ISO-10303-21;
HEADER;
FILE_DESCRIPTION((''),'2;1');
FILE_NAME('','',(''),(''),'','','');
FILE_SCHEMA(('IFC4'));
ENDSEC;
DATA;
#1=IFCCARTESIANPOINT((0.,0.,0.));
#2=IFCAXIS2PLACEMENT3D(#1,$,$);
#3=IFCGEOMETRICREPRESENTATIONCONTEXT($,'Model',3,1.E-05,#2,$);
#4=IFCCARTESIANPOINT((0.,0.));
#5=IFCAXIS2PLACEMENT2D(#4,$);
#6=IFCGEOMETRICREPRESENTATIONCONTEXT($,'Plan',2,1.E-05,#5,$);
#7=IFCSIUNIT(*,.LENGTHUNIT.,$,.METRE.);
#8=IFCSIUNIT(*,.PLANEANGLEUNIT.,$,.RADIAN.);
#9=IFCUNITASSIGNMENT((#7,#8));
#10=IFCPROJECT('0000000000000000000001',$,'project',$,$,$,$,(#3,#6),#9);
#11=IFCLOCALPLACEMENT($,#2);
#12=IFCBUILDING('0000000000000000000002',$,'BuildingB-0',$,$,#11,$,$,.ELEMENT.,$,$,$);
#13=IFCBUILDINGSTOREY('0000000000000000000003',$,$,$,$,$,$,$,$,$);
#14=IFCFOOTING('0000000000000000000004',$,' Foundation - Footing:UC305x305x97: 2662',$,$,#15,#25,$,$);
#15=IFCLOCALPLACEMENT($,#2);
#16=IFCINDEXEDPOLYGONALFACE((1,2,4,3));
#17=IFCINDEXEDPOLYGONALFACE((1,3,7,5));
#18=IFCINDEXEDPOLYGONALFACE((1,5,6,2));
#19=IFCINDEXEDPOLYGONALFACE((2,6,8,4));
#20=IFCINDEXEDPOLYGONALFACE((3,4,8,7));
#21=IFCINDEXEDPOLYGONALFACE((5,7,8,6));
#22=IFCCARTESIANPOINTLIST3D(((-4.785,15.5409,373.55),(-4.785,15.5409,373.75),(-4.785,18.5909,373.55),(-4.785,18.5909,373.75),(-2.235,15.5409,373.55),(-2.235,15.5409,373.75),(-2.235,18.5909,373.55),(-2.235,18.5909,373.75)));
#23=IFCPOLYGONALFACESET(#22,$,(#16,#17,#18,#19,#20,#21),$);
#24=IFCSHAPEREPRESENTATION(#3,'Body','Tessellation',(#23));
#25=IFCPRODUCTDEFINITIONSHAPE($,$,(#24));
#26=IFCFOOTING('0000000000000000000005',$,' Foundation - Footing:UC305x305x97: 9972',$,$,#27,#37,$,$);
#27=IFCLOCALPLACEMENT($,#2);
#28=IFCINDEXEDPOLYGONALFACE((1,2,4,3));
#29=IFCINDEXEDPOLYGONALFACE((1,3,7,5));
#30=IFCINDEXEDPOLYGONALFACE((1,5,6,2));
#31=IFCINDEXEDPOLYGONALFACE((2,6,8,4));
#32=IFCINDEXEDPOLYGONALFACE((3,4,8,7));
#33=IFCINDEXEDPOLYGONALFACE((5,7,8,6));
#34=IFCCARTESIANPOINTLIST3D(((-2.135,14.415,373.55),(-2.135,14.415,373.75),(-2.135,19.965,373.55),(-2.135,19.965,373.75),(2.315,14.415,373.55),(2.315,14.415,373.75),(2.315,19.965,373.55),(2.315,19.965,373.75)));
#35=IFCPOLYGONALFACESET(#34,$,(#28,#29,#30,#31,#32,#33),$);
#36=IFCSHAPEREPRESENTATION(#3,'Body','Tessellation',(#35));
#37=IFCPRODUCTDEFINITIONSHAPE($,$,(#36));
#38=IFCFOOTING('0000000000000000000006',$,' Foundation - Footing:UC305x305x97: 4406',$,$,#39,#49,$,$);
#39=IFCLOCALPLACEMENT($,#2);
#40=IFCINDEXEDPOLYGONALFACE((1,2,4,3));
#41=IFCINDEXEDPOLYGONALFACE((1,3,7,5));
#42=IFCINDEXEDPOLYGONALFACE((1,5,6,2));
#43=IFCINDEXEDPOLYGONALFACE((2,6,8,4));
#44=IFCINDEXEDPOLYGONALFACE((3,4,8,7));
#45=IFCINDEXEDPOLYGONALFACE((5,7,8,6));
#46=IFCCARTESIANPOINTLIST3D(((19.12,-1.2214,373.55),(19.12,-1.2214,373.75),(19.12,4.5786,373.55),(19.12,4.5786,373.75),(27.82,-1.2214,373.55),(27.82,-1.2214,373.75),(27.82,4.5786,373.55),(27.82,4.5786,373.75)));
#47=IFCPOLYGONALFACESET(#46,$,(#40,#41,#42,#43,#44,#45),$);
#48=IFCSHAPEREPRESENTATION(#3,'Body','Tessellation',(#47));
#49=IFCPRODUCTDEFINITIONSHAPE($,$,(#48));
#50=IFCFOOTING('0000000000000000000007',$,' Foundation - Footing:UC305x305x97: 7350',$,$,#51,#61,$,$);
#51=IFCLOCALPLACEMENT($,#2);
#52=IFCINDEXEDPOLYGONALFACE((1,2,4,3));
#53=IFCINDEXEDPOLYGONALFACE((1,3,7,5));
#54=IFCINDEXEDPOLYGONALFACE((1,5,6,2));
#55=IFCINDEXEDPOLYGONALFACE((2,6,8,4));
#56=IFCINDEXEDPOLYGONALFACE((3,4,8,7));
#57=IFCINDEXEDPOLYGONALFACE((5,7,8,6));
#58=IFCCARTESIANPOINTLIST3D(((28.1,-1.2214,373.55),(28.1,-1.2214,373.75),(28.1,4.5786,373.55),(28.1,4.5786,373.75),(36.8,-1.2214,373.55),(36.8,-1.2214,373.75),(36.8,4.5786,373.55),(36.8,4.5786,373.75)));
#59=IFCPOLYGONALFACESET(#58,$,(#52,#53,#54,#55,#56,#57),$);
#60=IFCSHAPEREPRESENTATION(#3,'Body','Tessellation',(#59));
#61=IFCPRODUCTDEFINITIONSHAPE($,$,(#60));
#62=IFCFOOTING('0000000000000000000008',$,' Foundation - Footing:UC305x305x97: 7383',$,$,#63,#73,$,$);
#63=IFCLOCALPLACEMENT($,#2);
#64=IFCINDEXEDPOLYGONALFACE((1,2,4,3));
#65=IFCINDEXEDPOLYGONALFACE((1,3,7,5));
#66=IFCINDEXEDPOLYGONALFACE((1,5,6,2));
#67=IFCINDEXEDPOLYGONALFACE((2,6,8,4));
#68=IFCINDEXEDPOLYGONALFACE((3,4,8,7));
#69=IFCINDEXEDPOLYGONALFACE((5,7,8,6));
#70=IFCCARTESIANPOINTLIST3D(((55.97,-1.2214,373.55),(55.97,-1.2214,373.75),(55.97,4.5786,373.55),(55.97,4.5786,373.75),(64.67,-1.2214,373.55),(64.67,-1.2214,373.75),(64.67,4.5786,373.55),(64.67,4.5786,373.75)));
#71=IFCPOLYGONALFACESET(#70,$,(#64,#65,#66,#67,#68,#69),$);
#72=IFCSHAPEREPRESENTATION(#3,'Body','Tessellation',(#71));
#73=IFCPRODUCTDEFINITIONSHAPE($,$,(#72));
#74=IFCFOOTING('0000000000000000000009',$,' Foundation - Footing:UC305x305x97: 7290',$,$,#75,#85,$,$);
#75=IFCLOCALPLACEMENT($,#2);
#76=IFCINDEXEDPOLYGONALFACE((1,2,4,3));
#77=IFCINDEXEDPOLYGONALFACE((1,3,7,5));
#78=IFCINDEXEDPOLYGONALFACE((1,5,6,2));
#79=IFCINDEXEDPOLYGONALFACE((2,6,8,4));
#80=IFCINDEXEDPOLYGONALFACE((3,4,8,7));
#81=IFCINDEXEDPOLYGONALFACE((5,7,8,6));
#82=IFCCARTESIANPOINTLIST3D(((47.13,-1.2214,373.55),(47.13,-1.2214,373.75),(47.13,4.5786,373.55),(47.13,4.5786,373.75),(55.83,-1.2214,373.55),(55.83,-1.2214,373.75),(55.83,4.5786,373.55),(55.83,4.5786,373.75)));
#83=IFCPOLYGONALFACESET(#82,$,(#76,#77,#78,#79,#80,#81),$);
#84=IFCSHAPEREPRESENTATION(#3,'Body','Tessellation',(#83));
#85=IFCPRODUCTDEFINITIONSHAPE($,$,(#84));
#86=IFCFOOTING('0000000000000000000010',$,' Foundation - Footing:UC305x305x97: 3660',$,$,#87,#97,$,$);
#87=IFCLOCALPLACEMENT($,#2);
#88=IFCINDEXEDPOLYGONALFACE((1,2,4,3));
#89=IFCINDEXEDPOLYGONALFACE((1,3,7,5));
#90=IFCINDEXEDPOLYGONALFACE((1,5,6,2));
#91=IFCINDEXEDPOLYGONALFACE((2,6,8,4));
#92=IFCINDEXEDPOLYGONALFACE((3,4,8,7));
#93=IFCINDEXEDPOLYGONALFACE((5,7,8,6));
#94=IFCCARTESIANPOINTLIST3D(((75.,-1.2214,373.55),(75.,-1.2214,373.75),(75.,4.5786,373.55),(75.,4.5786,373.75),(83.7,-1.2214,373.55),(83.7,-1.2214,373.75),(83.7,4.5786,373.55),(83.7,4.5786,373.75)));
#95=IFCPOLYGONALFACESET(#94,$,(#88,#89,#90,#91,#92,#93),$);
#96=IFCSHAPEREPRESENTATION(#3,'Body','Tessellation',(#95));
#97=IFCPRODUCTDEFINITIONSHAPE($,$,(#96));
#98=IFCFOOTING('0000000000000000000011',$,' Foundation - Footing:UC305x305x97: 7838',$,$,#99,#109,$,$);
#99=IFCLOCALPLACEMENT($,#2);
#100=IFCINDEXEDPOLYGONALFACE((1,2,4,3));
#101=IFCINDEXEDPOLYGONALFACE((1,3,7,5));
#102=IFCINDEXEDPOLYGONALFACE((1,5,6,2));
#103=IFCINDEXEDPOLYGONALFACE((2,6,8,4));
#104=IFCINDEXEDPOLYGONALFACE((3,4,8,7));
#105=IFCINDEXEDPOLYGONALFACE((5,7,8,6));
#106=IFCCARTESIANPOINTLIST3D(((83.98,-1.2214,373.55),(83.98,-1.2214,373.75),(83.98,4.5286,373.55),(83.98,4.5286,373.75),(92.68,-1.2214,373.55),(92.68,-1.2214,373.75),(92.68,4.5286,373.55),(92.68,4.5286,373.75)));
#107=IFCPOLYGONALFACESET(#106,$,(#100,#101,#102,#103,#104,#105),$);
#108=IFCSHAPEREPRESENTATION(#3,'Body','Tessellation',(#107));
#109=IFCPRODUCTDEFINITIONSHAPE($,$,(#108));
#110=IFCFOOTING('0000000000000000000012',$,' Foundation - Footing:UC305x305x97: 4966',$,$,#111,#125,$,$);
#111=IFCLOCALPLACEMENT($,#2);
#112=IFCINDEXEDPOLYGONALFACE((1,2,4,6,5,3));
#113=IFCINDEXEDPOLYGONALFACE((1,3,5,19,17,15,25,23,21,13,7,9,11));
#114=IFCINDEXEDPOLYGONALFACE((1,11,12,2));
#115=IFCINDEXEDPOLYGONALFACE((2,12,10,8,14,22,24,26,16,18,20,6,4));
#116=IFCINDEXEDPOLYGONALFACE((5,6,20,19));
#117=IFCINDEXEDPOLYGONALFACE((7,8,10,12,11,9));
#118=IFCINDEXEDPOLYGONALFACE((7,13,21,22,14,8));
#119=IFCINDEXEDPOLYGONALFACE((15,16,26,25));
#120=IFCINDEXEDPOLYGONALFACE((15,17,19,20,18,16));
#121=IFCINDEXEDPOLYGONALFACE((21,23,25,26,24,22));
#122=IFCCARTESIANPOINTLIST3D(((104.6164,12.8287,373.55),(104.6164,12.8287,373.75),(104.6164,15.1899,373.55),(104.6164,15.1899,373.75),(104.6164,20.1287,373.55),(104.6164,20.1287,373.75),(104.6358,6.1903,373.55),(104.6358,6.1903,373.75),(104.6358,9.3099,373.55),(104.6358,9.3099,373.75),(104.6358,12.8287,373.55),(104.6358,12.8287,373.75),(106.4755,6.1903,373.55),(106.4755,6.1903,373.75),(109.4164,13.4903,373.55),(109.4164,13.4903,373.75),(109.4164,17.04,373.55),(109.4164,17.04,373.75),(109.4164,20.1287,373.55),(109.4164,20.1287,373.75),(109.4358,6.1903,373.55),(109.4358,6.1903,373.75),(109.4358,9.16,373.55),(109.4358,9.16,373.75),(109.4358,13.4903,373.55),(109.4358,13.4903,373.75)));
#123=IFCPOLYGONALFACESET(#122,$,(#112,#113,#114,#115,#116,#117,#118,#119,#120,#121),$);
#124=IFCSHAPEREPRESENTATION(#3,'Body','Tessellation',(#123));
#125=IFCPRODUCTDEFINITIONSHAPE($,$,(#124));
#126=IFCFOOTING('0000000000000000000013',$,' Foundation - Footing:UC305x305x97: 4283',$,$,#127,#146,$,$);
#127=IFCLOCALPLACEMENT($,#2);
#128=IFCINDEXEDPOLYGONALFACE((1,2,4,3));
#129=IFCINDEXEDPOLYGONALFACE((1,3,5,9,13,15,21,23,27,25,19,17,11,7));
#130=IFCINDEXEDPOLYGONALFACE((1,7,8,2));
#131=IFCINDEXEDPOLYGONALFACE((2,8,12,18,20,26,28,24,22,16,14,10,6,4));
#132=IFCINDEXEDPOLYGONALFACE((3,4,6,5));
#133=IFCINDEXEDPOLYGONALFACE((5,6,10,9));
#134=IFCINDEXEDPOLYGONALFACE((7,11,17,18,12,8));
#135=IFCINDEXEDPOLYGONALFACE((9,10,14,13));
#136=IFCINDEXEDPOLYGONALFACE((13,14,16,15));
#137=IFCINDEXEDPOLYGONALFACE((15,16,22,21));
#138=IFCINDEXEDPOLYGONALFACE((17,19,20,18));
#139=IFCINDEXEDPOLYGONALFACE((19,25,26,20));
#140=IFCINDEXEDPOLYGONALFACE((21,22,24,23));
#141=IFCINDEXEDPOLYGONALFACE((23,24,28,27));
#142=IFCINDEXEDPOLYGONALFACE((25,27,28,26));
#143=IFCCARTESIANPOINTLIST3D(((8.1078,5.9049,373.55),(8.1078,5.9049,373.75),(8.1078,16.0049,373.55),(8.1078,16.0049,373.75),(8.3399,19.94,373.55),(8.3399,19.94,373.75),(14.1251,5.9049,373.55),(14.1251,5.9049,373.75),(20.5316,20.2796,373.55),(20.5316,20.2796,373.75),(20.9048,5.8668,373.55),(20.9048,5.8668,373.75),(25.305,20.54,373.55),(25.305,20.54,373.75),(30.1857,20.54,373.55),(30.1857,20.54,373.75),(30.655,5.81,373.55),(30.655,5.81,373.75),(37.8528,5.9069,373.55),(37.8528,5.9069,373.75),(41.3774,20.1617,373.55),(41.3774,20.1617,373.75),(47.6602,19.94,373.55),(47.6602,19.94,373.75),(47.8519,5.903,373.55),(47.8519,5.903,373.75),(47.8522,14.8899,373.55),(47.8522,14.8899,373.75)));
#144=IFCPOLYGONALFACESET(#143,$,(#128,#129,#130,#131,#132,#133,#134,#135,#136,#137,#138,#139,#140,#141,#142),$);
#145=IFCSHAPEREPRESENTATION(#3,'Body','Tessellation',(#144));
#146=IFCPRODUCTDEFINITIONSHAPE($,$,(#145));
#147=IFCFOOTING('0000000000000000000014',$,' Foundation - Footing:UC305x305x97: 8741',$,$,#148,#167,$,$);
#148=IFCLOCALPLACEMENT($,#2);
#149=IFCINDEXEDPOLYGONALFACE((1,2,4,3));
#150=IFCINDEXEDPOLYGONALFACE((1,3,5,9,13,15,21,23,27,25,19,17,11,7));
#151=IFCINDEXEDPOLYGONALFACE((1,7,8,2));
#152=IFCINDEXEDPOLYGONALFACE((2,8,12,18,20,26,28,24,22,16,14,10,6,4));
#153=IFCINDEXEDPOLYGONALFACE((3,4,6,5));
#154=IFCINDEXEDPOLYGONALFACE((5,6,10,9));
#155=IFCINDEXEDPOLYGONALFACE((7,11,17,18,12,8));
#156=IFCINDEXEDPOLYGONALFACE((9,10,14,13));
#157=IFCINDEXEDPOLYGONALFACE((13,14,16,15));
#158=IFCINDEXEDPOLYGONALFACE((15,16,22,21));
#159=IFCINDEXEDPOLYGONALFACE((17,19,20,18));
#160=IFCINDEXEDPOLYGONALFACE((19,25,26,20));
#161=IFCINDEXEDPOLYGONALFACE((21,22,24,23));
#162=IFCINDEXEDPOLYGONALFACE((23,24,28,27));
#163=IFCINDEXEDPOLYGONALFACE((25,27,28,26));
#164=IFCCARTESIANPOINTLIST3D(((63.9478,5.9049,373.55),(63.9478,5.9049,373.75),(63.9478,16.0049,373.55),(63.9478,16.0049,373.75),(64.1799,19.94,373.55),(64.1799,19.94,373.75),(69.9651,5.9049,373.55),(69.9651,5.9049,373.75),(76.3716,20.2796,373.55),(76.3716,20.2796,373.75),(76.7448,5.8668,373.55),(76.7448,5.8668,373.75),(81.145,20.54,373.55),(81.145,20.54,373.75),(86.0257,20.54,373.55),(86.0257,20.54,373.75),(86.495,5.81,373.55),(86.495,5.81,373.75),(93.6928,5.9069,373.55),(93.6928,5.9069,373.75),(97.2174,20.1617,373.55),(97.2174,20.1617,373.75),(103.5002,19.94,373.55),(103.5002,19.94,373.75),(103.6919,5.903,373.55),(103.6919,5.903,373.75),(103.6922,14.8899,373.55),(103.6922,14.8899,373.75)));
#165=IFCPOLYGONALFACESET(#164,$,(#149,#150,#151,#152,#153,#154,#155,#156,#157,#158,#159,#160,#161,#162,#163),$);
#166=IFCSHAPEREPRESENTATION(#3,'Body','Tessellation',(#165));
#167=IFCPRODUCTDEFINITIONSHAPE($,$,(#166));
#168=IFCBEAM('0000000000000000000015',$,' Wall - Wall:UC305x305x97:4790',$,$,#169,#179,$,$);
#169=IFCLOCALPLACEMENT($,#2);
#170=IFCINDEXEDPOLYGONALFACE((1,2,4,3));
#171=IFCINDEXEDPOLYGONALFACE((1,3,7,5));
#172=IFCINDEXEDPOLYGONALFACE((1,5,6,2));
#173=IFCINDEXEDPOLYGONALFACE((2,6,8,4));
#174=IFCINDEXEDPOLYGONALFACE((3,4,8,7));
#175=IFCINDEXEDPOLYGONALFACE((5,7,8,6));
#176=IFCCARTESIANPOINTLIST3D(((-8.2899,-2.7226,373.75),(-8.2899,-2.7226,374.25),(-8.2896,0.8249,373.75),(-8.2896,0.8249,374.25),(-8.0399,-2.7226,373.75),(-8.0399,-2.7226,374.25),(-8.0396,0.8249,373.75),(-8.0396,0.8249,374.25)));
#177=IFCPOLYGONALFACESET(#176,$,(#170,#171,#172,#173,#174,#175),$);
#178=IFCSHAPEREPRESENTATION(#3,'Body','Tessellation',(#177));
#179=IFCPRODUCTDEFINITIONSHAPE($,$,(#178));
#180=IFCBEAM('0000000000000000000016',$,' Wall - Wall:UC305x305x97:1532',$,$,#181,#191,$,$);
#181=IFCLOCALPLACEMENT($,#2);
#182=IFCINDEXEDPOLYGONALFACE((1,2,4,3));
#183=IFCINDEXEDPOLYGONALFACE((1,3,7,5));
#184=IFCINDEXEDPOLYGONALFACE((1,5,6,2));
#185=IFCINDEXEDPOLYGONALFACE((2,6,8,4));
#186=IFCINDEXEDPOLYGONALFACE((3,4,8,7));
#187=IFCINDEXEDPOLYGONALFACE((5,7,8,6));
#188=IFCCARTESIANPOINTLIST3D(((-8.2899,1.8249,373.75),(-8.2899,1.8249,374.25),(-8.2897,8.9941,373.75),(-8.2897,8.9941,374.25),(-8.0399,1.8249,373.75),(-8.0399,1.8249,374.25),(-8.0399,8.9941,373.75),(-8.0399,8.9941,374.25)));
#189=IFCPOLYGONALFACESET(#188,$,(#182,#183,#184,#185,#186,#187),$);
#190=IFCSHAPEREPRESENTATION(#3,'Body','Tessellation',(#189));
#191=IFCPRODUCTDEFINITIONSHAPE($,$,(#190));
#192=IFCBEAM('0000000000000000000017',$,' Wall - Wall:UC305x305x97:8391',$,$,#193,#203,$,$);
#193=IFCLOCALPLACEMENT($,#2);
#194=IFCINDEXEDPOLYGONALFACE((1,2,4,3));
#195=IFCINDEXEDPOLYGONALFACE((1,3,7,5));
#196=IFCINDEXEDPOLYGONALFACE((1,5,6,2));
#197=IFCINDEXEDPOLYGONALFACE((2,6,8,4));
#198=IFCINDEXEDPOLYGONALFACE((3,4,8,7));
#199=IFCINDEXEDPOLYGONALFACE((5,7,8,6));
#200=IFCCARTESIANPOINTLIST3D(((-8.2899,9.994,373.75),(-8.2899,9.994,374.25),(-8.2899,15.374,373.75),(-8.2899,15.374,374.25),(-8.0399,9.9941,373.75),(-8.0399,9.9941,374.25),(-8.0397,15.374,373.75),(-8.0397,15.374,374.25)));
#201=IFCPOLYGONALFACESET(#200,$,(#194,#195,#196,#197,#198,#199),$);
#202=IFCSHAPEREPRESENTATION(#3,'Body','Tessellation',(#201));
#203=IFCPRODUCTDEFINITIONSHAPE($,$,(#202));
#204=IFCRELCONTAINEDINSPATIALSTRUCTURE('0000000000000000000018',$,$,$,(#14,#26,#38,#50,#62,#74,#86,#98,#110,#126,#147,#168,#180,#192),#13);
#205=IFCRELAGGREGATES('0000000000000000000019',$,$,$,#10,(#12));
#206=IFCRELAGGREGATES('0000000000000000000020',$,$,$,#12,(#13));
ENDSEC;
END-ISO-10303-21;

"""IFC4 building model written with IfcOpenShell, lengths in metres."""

from ifc_helpers import new_model, si_unit, origin, origin_2d, place, context, project, spatial, polyline, outline, extrude, element, save


model = new_model("IFC4")

# Units and contexts
model_context = context("Model", 3, precision=1e-05, world=origin())
plan_context = context("Plan", 2, precision=1e-05, world=origin_2d())
ifc_project = project(units=[si_unit("LENGTHUNIT", "METRE"), si_unit("PLANEANGLEUNIT", "RADIAN")], contexts=[model_context, plan_context])

# Building, storey
building_placement = place(None, origin())
building = spatial("IfcBuilding", under=ifc_project, at=building_placement, Name="BuildingB-0", CompositionType="ELEMENT")
storey = spatial("IfcBuildingStorey", under=building)

# Footings
element("IfcFooting", 1, inside=storey, Name=" Foundation - Footing:UC305x305x97: 2662", context=model_context, shape_type="SweptSolid", body=[
    extrude(outline(polyline([(-4.785, 15.5409, 373.55), (-2.235, 15.5409, 373.55), (-2.235, 18.5909, 373.55), (-4.785, 18.5909, 373.55), (-4.785, 15.5409, 373.55)])), None, (0.0, 0.0, 1.0), 0.2),
])
element("IfcFooting", 2, inside=storey, Name=" Foundation - Footing:UC305x305x97: 9972", context=model_context, shape_type="SweptSolid", body=[
    extrude(outline(polyline([(-2.135, 14.415, 373.55), (2.315, 14.415, 373.55), (2.315, 19.965, 373.55), (-2.135, 19.965, 373.55), (-2.135, 14.415, 373.55)])), None, (0.0, 0.0, 1.0), 0.2),
])
element("IfcFooting", 3, inside=storey, Name=" Foundation - Footing:UC305x305x97: 4406", context=model_context, shape_type="SweptSolid", body=[
    extrude(outline(polyline([(19.12, -1.2214, 373.55), (27.82, -1.2214, 373.55), (27.82, 4.5786, 373.55), (19.12, 4.5786, 373.55), (19.12, -1.2214, 373.55)])), None, (0.0, 0.0, 1.0), 0.2),
])
element("IfcFooting", 4, inside=storey, Name=" Foundation - Footing:UC305x305x97: 7350", context=model_context, shape_type="SweptSolid", body=[
    extrude(outline(polyline([(28.1, -1.2214, 373.55), (36.8, -1.2214, 373.55), (36.8, 4.5786, 373.55), (28.1, 4.5786, 373.55), (28.1, -1.2214, 373.55)])), None, (0.0, 0.0, 1.0), 0.2),
])
element("IfcFooting", 5, inside=storey, Name=" Foundation - Footing:UC305x305x97: 7383", context=model_context, shape_type="SweptSolid", body=[
    extrude(outline(polyline([(55.97, -1.2214, 373.55), (64.67, -1.2214, 373.55), (64.67, 4.5786, 373.55), (55.97, 4.5786, 373.55), (55.97, -1.2214, 373.55)])), None, (0.0, 0.0, 1.0), 0.2),
])
element("IfcFooting", 6, inside=storey, Name=" Foundation - Footing:UC305x305x97: 7290", context=model_context, shape_type="SweptSolid", body=[
    extrude(outline(polyline([(47.13, -1.2214, 373.55), (55.83, -1.2214, 373.55), (55.83, 4.5786, 373.55), (47.13, 4.5786, 373.55), (47.13, -1.2214, 373.55)])), None, (0.0, 0.0, 1.0), 0.2),
])
element("IfcFooting", 7, inside=storey, Name=" Foundation - Footing:UC305x305x97: 3660", context=model_context, shape_type="SweptSolid", body=[
    extrude(outline(polyline([(75.0, -1.2214, 373.55), (83.7, -1.2214, 373.55), (83.7, 4.5786, 373.55), (75.0, 4.5786, 373.55), (75.0, -1.2214, 373.55)])), None, (0.0, 0.0, 1.0), 0.2),
])
element("IfcFooting", 8, inside=storey, Name=" Foundation - Footing:UC305x305x97: 7838", context=model_context, shape_type="SweptSolid", body=[
    extrude(outline(polyline([(92.68, -1.2214, 373.55), (83.98, -1.2214, 373.55), (83.98, 4.5286, 373.55), (92.68, 4.5286, 373.55), (92.68, -1.2214, 373.55)])), None, (0.0, 0.0, 1.0), 0.2),
])
element("IfcFooting", 9, inside=storey, Name=" Foundation - Footing:UC305x305x97: 4966", context=model_context, shape_type="SweptSolid", body=[
    extrude(outline(polyline([(104.6358, 12.8287, 373.55), (104.6164, 12.8287, 373.55), (104.6164, 15.1899, 373.55), (104.6164, 20.1287, 373.55), (109.4164, 20.1287, 373.55), (109.4164, 17.04, 373.55), (109.4164, 13.4903, 373.55), (109.4358, 13.4903, 373.55), (109.4358, 9.16, 373.55), (109.4358, 6.1903, 373.55), (106.4755, 6.1903, 373.55), (104.6358, 6.1903, 373.55), (104.6358, 9.3099, 373.55), (104.6358, 12.8287, 373.55)])), None, (0.0, 0.0, 1.0), 0.2),
])
element("IfcFooting", 10, inside=storey, Name=" Foundation - Footing:UC305x305x97: 4283", context=model_context, shape_type="SweptSolid", body=[
    extrude(outline(polyline([(8.3399, 19.94, 373.55), (20.5316, 20.2796, 373.55), (25.305, 20.54, 373.55), (30.1857, 20.54, 373.55), (41.3774, 20.1617, 373.55), (47.6602, 19.94, 373.55), (47.8522, 14.8899, 373.55), (47.8519, 5.903, 373.55), (37.8528, 5.9069, 373.55), (30.655, 5.81, 373.55), (20.9048, 5.8668, 373.55), (14.1251, 5.9049, 373.55), (8.1078, 5.9049, 373.55), (8.1078, 16.0049, 373.55), (8.3399, 19.94, 373.55)])), None, (0.0, 0.0, 1.0), 0.2),
])
element("IfcFooting", 11, inside=storey, Name=" Foundation - Footing:UC305x305x97: 8741", context=model_context, shape_type="SweptSolid", body=[
    extrude(outline(polyline([(64.1799, 19.94, 373.55), (76.3716, 20.2796, 373.55), (81.145, 20.54, 373.55), (86.0257, 20.54, 373.55), (97.2174, 20.1617, 373.55), (103.5002, 19.94, 373.55), (103.6922, 14.8899, 373.55), (103.6919, 5.903, 373.55), (93.6928, 5.9069, 373.55), (86.495, 5.81, 373.55), (76.7448, 5.8668, 373.55), (69.9651, 5.9049, 373.55), (63.9478, 5.9049, 373.55), (63.9478, 16.0049, 373.55), (64.1799, 19.94, 373.55)])), None, (0.0, 0.0, 1.0), 0.2),
])

# Beams
element("IfcBeam", 12, inside=storey, Name=" Wall - Wall:UC305x305x97:4790", context=model_context, shape_type="SweptSolid", body=[
    extrude(outline(polyline([(-8.2899, -2.7226, 373.75), (-8.0399, -2.7226, 373.75), (-8.0396, 0.8249, 373.75), (-8.2896, 0.8249, 373.75), (-8.2899, -2.7226, 373.75)])), None, (0.0, 0.0, 1.0), 0.5),
])
element("IfcBeam", 13, inside=storey, Name=" Wall - Wall:UC305x305x97:1532", context=model_context, shape_type="SweptSolid", body=[
    extrude(outline(polyline([(-8.2899, 1.8249, 373.75), (-8.0399, 1.8249, 373.75), (-8.0399, 8.9941, 373.75), (-8.2897, 8.9941, 373.75), (-8.2899, 1.8249, 373.75)])), None, (0.0, 0.0, 1.0), 0.5),
])
element("IfcBeam", 14, inside=storey, Name=" Wall - Wall:UC305x305x97:8391", context=model_context, shape_type="SweptSolid", body=[
    extrude(outline(polyline([(-8.2899, 9.994, 373.75), (-8.0399, 9.9941, 373.75), (-8.0397, 15.374, 373.75), (-8.2899, 15.374, 373.75), (-8.2899, 9.994, 373.75)])), None, (0.0, 0.0, 1.0), 0.5),
])

save(model, "model.ifc")
